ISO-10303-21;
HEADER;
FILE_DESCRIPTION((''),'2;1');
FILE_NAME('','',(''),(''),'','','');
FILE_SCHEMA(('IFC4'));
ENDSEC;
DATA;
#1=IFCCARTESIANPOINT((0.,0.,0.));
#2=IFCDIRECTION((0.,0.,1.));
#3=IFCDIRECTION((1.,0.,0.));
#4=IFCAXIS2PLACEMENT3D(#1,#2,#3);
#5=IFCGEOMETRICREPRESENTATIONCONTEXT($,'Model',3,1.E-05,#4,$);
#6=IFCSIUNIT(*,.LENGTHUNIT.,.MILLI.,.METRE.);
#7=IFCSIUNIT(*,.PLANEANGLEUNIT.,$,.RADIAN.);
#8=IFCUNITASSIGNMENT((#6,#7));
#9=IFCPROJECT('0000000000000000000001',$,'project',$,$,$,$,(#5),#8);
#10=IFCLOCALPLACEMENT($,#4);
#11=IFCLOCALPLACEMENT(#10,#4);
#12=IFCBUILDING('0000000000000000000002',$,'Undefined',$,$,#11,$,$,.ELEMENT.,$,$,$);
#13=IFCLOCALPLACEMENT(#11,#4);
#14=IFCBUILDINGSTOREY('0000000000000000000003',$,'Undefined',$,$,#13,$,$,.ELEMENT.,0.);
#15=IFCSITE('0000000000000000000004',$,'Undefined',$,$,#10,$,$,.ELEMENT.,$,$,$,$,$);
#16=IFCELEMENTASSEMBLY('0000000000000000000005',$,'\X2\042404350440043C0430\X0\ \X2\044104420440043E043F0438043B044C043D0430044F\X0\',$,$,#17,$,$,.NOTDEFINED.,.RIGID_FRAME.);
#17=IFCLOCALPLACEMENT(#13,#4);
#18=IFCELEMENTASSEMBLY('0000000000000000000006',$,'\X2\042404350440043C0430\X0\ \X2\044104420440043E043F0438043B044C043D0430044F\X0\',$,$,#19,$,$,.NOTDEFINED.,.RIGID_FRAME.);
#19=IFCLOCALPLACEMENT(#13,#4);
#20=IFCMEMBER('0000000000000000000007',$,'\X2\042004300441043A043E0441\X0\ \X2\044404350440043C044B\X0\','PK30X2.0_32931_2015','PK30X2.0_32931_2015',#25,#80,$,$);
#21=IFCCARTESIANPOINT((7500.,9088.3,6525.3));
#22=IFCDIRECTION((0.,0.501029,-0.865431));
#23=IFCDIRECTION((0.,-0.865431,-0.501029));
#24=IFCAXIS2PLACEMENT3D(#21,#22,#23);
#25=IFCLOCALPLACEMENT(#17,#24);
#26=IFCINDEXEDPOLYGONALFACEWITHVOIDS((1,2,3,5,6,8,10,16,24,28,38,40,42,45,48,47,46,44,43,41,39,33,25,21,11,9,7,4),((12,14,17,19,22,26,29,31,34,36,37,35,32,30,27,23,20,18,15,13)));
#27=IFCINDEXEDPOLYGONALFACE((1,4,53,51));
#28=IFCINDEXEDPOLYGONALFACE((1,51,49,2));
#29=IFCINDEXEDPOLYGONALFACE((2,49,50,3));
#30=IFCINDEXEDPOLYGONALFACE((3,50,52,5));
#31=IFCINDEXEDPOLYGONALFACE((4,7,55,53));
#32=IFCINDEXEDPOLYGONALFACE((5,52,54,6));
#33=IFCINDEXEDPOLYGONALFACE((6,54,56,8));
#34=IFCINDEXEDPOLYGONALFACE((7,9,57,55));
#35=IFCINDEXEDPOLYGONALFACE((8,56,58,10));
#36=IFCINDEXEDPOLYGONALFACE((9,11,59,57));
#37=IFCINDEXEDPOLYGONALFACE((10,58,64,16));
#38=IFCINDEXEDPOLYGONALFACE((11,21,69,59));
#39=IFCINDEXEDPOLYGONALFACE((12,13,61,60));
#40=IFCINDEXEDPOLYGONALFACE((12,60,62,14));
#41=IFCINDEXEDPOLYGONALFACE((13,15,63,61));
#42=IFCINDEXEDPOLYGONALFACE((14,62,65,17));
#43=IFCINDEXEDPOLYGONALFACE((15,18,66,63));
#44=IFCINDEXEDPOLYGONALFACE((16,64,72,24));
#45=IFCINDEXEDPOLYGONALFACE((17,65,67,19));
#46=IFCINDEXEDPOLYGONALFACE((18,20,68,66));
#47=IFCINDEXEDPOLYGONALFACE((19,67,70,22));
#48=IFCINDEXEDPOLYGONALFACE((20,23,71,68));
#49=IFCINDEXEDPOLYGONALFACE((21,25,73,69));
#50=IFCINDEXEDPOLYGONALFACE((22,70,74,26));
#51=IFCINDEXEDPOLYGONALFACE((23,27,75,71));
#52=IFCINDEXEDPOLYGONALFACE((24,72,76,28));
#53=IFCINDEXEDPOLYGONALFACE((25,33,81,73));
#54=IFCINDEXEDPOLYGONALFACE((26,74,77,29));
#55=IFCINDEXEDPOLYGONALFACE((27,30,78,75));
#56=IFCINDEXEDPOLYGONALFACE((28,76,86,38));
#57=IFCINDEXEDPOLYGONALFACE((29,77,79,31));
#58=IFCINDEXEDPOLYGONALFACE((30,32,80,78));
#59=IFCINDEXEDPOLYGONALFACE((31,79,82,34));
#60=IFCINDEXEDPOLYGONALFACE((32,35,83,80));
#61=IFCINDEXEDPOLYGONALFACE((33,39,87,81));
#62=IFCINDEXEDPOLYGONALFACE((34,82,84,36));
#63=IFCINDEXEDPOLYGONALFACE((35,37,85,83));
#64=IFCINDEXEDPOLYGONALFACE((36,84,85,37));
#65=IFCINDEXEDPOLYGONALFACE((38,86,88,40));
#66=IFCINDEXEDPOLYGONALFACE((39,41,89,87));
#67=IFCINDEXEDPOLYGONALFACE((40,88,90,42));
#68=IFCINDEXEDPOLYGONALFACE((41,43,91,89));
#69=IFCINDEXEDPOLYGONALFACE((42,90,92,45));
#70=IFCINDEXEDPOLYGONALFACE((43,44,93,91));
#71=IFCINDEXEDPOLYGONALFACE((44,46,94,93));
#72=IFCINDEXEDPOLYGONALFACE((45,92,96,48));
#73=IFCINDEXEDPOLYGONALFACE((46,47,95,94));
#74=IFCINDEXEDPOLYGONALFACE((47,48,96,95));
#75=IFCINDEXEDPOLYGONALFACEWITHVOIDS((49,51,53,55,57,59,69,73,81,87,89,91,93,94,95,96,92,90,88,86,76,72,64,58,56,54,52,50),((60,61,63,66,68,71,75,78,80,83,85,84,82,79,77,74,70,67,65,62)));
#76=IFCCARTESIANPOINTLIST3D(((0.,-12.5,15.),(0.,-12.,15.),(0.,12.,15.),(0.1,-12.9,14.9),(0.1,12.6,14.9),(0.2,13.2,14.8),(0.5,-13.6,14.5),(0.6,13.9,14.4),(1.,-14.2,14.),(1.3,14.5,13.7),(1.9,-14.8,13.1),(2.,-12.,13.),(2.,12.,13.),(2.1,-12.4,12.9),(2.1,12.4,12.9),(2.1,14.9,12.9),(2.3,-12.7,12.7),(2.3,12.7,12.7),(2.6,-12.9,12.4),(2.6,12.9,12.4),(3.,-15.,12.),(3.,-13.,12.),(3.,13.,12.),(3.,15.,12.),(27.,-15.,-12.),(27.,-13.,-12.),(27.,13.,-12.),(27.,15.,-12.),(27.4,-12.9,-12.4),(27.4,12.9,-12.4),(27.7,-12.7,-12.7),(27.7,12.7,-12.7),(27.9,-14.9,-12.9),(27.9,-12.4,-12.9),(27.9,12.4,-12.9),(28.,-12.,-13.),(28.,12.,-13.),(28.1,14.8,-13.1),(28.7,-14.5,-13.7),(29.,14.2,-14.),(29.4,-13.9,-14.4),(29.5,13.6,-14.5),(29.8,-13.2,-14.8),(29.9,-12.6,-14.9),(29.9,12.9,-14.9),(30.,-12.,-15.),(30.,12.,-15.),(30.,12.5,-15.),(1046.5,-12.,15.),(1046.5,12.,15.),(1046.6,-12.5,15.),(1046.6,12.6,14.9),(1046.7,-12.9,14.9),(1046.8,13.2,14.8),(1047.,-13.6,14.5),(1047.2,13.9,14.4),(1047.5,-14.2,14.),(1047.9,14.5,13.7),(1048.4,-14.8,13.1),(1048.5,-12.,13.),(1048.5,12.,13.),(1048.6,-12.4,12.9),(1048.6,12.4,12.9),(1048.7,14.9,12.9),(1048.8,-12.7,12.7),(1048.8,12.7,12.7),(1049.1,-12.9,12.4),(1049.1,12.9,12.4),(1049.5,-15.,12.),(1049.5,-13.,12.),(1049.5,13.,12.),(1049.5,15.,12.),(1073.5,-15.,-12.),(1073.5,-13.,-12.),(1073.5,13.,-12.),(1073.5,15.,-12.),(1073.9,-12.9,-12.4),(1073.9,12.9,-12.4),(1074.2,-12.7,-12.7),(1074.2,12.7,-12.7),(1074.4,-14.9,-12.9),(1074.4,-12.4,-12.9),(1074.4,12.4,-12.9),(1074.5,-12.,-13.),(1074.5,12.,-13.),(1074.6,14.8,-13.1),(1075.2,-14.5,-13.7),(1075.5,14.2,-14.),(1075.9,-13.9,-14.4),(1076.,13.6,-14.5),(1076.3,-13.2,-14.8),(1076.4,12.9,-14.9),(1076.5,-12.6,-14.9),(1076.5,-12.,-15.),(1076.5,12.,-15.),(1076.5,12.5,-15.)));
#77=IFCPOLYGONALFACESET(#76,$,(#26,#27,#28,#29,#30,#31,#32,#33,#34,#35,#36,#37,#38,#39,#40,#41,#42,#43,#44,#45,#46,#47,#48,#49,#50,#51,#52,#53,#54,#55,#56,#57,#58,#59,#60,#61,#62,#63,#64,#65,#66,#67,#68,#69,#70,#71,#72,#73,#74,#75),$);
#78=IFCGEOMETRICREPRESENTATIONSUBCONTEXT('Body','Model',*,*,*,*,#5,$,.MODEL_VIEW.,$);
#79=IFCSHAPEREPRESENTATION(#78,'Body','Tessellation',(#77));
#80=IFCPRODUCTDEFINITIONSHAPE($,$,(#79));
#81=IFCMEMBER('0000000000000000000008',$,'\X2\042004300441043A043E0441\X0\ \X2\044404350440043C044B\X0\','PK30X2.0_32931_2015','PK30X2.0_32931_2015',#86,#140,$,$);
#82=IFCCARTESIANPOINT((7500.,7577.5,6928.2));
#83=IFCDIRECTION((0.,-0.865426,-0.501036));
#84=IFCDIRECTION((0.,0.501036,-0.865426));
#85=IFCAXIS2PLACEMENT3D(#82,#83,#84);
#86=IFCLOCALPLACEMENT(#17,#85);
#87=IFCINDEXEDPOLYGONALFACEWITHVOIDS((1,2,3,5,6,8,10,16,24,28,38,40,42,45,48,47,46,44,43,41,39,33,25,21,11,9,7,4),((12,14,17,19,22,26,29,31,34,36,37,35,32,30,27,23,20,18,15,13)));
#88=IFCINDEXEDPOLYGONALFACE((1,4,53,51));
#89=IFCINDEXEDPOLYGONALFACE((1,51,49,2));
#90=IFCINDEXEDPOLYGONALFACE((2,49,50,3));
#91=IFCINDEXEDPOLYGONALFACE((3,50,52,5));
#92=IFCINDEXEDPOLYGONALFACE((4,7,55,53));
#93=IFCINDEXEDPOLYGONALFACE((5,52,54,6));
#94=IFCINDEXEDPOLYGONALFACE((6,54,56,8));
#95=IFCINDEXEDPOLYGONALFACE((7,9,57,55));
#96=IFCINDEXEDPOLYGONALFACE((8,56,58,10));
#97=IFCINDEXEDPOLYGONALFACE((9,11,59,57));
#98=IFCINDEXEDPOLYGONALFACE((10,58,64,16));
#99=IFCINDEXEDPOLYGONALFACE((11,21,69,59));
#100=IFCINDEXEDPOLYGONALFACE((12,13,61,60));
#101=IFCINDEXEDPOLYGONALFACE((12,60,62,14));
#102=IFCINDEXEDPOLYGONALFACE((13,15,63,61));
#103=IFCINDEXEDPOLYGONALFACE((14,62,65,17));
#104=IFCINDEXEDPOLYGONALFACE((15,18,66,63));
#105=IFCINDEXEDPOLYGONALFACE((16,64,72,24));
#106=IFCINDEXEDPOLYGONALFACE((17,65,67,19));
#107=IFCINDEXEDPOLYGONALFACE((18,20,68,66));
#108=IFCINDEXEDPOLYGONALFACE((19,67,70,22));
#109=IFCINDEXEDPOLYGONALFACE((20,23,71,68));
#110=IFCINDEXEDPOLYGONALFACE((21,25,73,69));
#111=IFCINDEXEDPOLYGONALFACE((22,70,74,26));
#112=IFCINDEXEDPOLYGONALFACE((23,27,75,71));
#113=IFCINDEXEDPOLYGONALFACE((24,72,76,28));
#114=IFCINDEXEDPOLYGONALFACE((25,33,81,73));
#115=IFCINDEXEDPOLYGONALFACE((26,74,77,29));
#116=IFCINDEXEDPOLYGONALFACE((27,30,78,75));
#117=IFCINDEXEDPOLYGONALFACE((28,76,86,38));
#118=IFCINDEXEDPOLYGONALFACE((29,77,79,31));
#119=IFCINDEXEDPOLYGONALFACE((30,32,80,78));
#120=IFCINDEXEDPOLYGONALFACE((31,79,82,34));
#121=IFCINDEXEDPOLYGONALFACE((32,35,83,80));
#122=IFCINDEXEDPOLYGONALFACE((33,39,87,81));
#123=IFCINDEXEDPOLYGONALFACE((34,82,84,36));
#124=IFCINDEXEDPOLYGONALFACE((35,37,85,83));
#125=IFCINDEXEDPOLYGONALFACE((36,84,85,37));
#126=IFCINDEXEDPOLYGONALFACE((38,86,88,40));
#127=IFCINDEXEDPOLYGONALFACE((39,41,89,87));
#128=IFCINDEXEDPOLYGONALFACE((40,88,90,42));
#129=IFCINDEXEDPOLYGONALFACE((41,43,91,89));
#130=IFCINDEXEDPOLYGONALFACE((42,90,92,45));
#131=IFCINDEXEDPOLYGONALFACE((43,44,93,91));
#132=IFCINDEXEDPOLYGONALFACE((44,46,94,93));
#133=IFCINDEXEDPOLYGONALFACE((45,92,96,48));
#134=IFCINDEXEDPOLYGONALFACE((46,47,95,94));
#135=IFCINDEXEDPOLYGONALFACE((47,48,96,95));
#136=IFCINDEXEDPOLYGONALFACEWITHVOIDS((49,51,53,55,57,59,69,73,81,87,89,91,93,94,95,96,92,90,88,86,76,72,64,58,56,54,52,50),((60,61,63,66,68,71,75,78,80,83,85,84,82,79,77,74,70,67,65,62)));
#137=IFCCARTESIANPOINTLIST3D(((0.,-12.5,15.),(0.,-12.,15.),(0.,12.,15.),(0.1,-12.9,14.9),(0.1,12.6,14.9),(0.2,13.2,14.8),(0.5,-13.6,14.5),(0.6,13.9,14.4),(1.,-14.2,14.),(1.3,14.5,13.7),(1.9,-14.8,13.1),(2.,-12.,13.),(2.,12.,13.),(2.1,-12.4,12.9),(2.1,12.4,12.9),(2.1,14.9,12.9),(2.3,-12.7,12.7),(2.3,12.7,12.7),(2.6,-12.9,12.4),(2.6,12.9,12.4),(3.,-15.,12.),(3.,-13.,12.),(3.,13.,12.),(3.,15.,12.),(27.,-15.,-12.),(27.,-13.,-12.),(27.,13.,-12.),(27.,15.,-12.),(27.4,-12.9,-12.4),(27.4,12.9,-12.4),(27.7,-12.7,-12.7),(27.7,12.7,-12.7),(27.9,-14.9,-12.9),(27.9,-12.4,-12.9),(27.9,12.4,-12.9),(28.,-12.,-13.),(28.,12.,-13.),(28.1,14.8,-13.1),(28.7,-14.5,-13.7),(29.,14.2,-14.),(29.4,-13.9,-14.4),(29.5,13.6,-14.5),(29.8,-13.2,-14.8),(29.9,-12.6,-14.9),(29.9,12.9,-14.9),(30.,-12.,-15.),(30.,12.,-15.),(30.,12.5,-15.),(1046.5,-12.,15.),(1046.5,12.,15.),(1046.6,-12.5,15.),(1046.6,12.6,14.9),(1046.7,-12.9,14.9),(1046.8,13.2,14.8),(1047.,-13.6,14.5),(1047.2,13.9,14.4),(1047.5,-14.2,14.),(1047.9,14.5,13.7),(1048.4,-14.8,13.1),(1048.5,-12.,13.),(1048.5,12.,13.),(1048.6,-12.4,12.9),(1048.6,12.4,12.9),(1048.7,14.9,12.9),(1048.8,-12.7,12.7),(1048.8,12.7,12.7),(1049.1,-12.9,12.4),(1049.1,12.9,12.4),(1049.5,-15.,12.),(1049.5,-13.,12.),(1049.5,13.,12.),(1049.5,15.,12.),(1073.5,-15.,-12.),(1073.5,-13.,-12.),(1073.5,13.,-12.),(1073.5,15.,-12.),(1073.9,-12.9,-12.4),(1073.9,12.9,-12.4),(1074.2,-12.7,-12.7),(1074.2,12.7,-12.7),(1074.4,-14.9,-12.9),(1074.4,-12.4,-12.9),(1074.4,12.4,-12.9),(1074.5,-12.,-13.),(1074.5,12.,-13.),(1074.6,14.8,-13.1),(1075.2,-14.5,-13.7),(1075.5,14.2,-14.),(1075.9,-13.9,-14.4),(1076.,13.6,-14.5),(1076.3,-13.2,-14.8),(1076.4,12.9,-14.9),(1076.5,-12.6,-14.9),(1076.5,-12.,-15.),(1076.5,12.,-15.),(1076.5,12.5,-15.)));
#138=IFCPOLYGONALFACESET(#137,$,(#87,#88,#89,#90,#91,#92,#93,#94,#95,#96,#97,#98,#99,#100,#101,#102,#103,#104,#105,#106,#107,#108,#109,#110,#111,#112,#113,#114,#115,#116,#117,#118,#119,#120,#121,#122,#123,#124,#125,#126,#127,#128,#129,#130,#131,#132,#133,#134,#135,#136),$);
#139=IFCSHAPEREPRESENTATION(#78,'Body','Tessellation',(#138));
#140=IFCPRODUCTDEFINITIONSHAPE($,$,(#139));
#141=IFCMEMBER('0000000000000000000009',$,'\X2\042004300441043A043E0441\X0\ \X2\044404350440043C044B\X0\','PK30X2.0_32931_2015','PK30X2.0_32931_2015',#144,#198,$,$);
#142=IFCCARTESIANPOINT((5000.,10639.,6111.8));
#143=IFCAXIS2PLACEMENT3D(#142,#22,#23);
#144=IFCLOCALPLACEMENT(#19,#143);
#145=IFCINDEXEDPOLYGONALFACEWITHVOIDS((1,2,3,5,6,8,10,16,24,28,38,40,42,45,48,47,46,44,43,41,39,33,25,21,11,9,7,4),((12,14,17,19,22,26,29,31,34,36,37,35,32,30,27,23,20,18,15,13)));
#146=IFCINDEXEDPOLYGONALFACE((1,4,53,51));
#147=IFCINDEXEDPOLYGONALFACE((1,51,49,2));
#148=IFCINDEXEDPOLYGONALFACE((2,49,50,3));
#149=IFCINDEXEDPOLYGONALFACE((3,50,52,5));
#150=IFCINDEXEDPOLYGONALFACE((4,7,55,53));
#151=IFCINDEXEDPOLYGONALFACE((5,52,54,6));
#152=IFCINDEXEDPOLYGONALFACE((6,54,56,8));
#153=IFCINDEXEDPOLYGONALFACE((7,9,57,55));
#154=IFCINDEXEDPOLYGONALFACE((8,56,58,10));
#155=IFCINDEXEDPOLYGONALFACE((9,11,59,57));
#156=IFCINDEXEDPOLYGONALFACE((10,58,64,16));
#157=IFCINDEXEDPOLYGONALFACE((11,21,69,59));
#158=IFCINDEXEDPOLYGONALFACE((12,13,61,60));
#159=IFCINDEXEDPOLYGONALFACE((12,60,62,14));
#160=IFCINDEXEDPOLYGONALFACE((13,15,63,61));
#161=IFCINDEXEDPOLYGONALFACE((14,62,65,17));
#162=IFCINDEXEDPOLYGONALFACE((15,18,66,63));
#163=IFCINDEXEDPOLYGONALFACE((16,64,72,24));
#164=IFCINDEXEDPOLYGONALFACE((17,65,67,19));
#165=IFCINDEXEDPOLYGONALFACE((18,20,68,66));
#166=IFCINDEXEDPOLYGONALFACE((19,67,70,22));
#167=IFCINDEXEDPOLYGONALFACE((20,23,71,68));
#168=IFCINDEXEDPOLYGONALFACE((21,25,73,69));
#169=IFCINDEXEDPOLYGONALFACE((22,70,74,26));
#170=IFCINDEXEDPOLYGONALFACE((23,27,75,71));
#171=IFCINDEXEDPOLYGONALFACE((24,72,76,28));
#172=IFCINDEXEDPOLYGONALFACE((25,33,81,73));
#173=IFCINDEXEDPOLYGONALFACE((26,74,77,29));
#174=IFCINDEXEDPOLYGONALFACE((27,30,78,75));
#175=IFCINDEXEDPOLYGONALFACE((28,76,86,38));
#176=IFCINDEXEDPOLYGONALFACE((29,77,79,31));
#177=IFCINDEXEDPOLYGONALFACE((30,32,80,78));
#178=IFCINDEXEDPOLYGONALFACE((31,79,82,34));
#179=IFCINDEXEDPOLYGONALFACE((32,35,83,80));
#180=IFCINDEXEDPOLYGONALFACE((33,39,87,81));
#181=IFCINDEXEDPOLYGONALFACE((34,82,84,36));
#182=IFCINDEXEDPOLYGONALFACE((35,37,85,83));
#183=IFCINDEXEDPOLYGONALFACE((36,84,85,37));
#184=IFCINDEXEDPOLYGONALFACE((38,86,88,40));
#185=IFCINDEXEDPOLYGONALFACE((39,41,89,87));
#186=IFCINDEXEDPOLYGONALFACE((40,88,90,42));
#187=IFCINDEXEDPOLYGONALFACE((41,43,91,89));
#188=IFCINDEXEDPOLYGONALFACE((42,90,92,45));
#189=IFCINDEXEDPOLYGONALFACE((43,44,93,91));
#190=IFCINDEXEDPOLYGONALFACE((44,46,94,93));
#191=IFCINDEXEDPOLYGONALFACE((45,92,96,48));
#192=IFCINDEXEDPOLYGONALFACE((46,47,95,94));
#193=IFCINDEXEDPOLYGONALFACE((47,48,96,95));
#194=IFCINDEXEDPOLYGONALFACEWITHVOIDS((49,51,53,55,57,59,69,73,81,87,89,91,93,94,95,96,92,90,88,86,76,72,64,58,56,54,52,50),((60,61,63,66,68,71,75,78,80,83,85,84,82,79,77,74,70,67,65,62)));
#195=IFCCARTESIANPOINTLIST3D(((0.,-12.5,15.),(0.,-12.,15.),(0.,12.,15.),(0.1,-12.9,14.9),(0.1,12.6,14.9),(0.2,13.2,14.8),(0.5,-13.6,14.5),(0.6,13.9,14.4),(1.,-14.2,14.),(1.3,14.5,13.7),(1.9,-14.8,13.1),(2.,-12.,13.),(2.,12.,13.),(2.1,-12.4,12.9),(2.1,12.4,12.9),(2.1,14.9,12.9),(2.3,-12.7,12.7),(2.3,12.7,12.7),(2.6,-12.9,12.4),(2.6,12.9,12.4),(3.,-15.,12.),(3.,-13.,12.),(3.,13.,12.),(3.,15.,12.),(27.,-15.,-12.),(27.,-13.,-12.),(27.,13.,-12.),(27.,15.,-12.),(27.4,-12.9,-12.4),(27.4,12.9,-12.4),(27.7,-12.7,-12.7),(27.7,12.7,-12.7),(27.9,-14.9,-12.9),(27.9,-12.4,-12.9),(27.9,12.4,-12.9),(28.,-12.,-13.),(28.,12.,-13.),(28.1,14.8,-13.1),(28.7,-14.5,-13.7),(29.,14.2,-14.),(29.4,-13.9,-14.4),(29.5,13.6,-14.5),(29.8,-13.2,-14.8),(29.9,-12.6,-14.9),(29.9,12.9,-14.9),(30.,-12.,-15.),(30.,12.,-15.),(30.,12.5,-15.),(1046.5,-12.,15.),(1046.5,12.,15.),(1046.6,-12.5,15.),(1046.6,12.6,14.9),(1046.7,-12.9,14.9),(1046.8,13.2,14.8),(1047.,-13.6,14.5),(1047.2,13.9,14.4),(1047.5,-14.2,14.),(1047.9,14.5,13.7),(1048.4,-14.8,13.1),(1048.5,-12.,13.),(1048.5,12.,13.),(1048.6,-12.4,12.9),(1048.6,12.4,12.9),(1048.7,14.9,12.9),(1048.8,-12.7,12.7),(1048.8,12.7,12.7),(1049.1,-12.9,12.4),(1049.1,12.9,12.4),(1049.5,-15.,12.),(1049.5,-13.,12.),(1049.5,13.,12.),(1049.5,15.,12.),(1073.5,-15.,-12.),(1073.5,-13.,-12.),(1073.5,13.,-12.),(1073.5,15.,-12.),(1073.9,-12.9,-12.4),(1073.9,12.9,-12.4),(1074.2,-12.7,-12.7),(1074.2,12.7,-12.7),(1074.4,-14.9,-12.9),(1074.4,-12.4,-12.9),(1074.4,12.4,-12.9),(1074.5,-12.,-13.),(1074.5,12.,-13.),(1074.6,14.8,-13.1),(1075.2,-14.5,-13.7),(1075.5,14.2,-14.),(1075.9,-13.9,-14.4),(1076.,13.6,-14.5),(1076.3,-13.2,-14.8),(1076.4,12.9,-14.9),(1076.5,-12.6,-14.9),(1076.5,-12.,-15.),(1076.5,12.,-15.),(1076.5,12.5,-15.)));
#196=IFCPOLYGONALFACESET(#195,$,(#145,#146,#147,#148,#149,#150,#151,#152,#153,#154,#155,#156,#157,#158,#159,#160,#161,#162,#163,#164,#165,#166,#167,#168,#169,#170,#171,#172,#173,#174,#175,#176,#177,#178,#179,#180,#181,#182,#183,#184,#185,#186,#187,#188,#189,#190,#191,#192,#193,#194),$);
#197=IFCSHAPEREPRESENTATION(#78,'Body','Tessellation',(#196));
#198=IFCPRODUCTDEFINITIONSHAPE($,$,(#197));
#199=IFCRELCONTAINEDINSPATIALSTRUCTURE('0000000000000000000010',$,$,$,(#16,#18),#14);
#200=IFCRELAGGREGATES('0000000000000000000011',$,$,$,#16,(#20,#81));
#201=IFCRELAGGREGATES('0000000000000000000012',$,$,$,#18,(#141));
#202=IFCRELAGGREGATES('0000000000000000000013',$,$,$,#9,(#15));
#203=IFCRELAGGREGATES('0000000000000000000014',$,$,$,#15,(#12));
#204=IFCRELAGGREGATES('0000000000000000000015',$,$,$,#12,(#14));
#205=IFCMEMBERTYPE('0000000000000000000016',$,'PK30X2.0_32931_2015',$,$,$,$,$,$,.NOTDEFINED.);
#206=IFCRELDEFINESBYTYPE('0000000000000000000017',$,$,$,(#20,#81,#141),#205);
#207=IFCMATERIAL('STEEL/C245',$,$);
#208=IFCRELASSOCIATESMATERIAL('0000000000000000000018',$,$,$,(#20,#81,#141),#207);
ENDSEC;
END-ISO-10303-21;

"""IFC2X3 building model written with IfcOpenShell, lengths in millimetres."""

from ifc_helpers import new_model, si_unit, frame, origin_with_axes, origin_2d_with_axis, place, context, subcontext, project, spatial, hollow_rectangle, extrude, clip, halfspace, material, type_object, element, aggregate, save


model = new_model("IFC2X3")

# Units and contexts
model_context = context("Model", 3, precision=1e-05, world=origin_with_axes())
body_context = subcontext(model_context, "Body", "Model", "MODEL_VIEW")
ifc_project = project(units=[si_unit("LENGTHUNIT", "METRE", prefix="MILLI"), si_unit("PLANEANGLEUNIT", "RADIAN")], contexts=[model_context])

# Site, building, storey
site_placement = place(None, origin_with_axes())
site = spatial("IfcSite", under=ifc_project, at=site_placement, Name="Undefined", CompositionType="ELEMENT")
building_placement = place(site_placement, origin_with_axes())
building = spatial("IfcBuilding", under=site, at=building_placement, Name="Undefined", CompositionType="ELEMENT")
storey_placement = place(building_placement, origin_with_axes())
storey = spatial("IfcBuildingStorey", under=building, at=storey_placement, Name="Undefined", CompositionType="ELEMENT", Elevation=0.0)

# Element assemblies
assembly_1_placement = place(storey_placement, origin_with_axes())
assembly_1 = element("IfcElementAssembly", 1, at=assembly_1_placement, inside=storey, Name="Ферма стропильная", AssemblyPlace="NOTDEFINED", PredefinedType="RIGID_FRAME")
ifc_material_1 = material(Name="STEEL/C245")
assembly_2_placement = place(storey_placement, origin_with_axes())
assembly_2 = element("IfcElementAssembly", 2, at=assembly_2_placement, inside=storey, Name="Ферма стропильная", AssemblyPlace="NOTDEFINED", PredefinedType="RIGID_FRAME")

# Members
member_type = type_object("IfcMemberType", Name="PK30X2.0_32931_2015", PredefinedType="NOTDEFINED")
member_1_placement = place(assembly_1_placement, frame((7500.0, 9088.3, 6525.3), z_axis=(0.0, 0.501029, -0.865431), x_axis=(0.0, -0.865431, -0.501029)))
member_1 = element("IfcMember", 3, at=member_1_placement, type_object=member_type, material=ifc_material_1, Name="Раскос фермы", Description="PK30X2.0_32931_2015", ObjectType="PK30X2.0_32931_2015", context=body_context, shape_type="Clipping", body=[
    clip(clip(extrude(hollow_rectangle(XDim=30.0, YDim=30.0, WallThickness=2.0, InnerFilletRadius=1.0, OuterFilletRadius=3.0, at=origin_2d_with_axis()), frame((1102.9, 0.0, 0.0), z_axis=(-1.0, 0.0, 0.0), x_axis=(0.0, -1.0, 0.0)), (0.0, 0.0, 1.0), 1129.2), halfspace(frame((1060.0, 0.0, 1.5), z_axis=(-0.707107, 0.0, -0.707107), x_axis=(0.707107, 0.0, -0.707107)), True)), halfspace(frame((34.5, 0.0, -19.5), z_axis=(-0.707107, 0.0, -0.707107), x_axis=(0.707107, 0.0, -0.707107)), False)),
])
member_2_placement = place(assembly_1_placement, frame((7500.0, 7577.5, 6928.2), z_axis=(0.0, -0.865426, -0.501036), x_axis=(0.0, 0.501036, -0.865426)))
member_2 = element("IfcMember", 4, at=member_2_placement, type_object=member_type, material=ifc_material_1, Name="Раскос фермы", Description="PK30X2.0_32931_2015", ObjectType="PK30X2.0_32931_2015", context=body_context, shape_type="Clipping", body=[
    clip(clip(extrude(hollow_rectangle(XDim=30.0, YDim=30.0, WallThickness=2.0, InnerFilletRadius=1.0, OuterFilletRadius=3.0, at=origin_2d_with_axis()), frame((1091.8, 0.0, 0.0), z_axis=(-1.0, 0.0, 0.0), x_axis=(0.0, -1.0, 0.0)), (0.0, 0.0, 1.0), 1107.1), halfspace(frame((1060.0, 0.0, 1.5), z_axis=(-0.707107, 0.0, -0.707107), x_axis=(0.707107, 0.0, -0.707107)), True)), halfspace(frame((34.5, 0.0, -19.5), z_axis=(-0.707107, 0.0, -0.707107), x_axis=(0.707107, 0.0, -0.707107)), False)),
])
aggregate(assembly_1, [member_1, member_2])
member_3_placement = place(assembly_2_placement, frame((5000.0, 10639.0, 6111.8), z_axis=(0.0, 0.501029, -0.865431), x_axis=(0.0, -0.865431, -0.501029)))
member_3 = element("IfcMember", 5, at=member_3_placement, type_object=member_type, material=ifc_material_1, Name="Раскос фермы", Description="PK30X2.0_32931_2015", ObjectType="PK30X2.0_32931_2015", context=body_context, shape_type="Clipping", body=[
    clip(clip(extrude(hollow_rectangle(XDim=30.0, YDim=30.0, WallThickness=2.0, InnerFilletRadius=1.0, OuterFilletRadius=3.0, at=origin_2d_with_axis()), frame((1102.9, 0.0, 0.0), z_axis=(-1.0, 0.0, 0.0), x_axis=(0.0, -1.0, 0.0)), (0.0, 0.0, 1.0), 1129.2), halfspace(frame((1060.0, 0.0, 1.5), z_axis=(-0.707107, 0.0, -0.707107), x_axis=(0.707107, 0.0, -0.707107)), True)), halfspace(frame((34.5, 0.0, -19.5), z_axis=(-0.707107, 0.0, -0.707107), x_axis=(0.707107, 0.0, -0.707107)), False)),
])
aggregate(assembly_2, [member_3])

save(model, "model.ifc")
